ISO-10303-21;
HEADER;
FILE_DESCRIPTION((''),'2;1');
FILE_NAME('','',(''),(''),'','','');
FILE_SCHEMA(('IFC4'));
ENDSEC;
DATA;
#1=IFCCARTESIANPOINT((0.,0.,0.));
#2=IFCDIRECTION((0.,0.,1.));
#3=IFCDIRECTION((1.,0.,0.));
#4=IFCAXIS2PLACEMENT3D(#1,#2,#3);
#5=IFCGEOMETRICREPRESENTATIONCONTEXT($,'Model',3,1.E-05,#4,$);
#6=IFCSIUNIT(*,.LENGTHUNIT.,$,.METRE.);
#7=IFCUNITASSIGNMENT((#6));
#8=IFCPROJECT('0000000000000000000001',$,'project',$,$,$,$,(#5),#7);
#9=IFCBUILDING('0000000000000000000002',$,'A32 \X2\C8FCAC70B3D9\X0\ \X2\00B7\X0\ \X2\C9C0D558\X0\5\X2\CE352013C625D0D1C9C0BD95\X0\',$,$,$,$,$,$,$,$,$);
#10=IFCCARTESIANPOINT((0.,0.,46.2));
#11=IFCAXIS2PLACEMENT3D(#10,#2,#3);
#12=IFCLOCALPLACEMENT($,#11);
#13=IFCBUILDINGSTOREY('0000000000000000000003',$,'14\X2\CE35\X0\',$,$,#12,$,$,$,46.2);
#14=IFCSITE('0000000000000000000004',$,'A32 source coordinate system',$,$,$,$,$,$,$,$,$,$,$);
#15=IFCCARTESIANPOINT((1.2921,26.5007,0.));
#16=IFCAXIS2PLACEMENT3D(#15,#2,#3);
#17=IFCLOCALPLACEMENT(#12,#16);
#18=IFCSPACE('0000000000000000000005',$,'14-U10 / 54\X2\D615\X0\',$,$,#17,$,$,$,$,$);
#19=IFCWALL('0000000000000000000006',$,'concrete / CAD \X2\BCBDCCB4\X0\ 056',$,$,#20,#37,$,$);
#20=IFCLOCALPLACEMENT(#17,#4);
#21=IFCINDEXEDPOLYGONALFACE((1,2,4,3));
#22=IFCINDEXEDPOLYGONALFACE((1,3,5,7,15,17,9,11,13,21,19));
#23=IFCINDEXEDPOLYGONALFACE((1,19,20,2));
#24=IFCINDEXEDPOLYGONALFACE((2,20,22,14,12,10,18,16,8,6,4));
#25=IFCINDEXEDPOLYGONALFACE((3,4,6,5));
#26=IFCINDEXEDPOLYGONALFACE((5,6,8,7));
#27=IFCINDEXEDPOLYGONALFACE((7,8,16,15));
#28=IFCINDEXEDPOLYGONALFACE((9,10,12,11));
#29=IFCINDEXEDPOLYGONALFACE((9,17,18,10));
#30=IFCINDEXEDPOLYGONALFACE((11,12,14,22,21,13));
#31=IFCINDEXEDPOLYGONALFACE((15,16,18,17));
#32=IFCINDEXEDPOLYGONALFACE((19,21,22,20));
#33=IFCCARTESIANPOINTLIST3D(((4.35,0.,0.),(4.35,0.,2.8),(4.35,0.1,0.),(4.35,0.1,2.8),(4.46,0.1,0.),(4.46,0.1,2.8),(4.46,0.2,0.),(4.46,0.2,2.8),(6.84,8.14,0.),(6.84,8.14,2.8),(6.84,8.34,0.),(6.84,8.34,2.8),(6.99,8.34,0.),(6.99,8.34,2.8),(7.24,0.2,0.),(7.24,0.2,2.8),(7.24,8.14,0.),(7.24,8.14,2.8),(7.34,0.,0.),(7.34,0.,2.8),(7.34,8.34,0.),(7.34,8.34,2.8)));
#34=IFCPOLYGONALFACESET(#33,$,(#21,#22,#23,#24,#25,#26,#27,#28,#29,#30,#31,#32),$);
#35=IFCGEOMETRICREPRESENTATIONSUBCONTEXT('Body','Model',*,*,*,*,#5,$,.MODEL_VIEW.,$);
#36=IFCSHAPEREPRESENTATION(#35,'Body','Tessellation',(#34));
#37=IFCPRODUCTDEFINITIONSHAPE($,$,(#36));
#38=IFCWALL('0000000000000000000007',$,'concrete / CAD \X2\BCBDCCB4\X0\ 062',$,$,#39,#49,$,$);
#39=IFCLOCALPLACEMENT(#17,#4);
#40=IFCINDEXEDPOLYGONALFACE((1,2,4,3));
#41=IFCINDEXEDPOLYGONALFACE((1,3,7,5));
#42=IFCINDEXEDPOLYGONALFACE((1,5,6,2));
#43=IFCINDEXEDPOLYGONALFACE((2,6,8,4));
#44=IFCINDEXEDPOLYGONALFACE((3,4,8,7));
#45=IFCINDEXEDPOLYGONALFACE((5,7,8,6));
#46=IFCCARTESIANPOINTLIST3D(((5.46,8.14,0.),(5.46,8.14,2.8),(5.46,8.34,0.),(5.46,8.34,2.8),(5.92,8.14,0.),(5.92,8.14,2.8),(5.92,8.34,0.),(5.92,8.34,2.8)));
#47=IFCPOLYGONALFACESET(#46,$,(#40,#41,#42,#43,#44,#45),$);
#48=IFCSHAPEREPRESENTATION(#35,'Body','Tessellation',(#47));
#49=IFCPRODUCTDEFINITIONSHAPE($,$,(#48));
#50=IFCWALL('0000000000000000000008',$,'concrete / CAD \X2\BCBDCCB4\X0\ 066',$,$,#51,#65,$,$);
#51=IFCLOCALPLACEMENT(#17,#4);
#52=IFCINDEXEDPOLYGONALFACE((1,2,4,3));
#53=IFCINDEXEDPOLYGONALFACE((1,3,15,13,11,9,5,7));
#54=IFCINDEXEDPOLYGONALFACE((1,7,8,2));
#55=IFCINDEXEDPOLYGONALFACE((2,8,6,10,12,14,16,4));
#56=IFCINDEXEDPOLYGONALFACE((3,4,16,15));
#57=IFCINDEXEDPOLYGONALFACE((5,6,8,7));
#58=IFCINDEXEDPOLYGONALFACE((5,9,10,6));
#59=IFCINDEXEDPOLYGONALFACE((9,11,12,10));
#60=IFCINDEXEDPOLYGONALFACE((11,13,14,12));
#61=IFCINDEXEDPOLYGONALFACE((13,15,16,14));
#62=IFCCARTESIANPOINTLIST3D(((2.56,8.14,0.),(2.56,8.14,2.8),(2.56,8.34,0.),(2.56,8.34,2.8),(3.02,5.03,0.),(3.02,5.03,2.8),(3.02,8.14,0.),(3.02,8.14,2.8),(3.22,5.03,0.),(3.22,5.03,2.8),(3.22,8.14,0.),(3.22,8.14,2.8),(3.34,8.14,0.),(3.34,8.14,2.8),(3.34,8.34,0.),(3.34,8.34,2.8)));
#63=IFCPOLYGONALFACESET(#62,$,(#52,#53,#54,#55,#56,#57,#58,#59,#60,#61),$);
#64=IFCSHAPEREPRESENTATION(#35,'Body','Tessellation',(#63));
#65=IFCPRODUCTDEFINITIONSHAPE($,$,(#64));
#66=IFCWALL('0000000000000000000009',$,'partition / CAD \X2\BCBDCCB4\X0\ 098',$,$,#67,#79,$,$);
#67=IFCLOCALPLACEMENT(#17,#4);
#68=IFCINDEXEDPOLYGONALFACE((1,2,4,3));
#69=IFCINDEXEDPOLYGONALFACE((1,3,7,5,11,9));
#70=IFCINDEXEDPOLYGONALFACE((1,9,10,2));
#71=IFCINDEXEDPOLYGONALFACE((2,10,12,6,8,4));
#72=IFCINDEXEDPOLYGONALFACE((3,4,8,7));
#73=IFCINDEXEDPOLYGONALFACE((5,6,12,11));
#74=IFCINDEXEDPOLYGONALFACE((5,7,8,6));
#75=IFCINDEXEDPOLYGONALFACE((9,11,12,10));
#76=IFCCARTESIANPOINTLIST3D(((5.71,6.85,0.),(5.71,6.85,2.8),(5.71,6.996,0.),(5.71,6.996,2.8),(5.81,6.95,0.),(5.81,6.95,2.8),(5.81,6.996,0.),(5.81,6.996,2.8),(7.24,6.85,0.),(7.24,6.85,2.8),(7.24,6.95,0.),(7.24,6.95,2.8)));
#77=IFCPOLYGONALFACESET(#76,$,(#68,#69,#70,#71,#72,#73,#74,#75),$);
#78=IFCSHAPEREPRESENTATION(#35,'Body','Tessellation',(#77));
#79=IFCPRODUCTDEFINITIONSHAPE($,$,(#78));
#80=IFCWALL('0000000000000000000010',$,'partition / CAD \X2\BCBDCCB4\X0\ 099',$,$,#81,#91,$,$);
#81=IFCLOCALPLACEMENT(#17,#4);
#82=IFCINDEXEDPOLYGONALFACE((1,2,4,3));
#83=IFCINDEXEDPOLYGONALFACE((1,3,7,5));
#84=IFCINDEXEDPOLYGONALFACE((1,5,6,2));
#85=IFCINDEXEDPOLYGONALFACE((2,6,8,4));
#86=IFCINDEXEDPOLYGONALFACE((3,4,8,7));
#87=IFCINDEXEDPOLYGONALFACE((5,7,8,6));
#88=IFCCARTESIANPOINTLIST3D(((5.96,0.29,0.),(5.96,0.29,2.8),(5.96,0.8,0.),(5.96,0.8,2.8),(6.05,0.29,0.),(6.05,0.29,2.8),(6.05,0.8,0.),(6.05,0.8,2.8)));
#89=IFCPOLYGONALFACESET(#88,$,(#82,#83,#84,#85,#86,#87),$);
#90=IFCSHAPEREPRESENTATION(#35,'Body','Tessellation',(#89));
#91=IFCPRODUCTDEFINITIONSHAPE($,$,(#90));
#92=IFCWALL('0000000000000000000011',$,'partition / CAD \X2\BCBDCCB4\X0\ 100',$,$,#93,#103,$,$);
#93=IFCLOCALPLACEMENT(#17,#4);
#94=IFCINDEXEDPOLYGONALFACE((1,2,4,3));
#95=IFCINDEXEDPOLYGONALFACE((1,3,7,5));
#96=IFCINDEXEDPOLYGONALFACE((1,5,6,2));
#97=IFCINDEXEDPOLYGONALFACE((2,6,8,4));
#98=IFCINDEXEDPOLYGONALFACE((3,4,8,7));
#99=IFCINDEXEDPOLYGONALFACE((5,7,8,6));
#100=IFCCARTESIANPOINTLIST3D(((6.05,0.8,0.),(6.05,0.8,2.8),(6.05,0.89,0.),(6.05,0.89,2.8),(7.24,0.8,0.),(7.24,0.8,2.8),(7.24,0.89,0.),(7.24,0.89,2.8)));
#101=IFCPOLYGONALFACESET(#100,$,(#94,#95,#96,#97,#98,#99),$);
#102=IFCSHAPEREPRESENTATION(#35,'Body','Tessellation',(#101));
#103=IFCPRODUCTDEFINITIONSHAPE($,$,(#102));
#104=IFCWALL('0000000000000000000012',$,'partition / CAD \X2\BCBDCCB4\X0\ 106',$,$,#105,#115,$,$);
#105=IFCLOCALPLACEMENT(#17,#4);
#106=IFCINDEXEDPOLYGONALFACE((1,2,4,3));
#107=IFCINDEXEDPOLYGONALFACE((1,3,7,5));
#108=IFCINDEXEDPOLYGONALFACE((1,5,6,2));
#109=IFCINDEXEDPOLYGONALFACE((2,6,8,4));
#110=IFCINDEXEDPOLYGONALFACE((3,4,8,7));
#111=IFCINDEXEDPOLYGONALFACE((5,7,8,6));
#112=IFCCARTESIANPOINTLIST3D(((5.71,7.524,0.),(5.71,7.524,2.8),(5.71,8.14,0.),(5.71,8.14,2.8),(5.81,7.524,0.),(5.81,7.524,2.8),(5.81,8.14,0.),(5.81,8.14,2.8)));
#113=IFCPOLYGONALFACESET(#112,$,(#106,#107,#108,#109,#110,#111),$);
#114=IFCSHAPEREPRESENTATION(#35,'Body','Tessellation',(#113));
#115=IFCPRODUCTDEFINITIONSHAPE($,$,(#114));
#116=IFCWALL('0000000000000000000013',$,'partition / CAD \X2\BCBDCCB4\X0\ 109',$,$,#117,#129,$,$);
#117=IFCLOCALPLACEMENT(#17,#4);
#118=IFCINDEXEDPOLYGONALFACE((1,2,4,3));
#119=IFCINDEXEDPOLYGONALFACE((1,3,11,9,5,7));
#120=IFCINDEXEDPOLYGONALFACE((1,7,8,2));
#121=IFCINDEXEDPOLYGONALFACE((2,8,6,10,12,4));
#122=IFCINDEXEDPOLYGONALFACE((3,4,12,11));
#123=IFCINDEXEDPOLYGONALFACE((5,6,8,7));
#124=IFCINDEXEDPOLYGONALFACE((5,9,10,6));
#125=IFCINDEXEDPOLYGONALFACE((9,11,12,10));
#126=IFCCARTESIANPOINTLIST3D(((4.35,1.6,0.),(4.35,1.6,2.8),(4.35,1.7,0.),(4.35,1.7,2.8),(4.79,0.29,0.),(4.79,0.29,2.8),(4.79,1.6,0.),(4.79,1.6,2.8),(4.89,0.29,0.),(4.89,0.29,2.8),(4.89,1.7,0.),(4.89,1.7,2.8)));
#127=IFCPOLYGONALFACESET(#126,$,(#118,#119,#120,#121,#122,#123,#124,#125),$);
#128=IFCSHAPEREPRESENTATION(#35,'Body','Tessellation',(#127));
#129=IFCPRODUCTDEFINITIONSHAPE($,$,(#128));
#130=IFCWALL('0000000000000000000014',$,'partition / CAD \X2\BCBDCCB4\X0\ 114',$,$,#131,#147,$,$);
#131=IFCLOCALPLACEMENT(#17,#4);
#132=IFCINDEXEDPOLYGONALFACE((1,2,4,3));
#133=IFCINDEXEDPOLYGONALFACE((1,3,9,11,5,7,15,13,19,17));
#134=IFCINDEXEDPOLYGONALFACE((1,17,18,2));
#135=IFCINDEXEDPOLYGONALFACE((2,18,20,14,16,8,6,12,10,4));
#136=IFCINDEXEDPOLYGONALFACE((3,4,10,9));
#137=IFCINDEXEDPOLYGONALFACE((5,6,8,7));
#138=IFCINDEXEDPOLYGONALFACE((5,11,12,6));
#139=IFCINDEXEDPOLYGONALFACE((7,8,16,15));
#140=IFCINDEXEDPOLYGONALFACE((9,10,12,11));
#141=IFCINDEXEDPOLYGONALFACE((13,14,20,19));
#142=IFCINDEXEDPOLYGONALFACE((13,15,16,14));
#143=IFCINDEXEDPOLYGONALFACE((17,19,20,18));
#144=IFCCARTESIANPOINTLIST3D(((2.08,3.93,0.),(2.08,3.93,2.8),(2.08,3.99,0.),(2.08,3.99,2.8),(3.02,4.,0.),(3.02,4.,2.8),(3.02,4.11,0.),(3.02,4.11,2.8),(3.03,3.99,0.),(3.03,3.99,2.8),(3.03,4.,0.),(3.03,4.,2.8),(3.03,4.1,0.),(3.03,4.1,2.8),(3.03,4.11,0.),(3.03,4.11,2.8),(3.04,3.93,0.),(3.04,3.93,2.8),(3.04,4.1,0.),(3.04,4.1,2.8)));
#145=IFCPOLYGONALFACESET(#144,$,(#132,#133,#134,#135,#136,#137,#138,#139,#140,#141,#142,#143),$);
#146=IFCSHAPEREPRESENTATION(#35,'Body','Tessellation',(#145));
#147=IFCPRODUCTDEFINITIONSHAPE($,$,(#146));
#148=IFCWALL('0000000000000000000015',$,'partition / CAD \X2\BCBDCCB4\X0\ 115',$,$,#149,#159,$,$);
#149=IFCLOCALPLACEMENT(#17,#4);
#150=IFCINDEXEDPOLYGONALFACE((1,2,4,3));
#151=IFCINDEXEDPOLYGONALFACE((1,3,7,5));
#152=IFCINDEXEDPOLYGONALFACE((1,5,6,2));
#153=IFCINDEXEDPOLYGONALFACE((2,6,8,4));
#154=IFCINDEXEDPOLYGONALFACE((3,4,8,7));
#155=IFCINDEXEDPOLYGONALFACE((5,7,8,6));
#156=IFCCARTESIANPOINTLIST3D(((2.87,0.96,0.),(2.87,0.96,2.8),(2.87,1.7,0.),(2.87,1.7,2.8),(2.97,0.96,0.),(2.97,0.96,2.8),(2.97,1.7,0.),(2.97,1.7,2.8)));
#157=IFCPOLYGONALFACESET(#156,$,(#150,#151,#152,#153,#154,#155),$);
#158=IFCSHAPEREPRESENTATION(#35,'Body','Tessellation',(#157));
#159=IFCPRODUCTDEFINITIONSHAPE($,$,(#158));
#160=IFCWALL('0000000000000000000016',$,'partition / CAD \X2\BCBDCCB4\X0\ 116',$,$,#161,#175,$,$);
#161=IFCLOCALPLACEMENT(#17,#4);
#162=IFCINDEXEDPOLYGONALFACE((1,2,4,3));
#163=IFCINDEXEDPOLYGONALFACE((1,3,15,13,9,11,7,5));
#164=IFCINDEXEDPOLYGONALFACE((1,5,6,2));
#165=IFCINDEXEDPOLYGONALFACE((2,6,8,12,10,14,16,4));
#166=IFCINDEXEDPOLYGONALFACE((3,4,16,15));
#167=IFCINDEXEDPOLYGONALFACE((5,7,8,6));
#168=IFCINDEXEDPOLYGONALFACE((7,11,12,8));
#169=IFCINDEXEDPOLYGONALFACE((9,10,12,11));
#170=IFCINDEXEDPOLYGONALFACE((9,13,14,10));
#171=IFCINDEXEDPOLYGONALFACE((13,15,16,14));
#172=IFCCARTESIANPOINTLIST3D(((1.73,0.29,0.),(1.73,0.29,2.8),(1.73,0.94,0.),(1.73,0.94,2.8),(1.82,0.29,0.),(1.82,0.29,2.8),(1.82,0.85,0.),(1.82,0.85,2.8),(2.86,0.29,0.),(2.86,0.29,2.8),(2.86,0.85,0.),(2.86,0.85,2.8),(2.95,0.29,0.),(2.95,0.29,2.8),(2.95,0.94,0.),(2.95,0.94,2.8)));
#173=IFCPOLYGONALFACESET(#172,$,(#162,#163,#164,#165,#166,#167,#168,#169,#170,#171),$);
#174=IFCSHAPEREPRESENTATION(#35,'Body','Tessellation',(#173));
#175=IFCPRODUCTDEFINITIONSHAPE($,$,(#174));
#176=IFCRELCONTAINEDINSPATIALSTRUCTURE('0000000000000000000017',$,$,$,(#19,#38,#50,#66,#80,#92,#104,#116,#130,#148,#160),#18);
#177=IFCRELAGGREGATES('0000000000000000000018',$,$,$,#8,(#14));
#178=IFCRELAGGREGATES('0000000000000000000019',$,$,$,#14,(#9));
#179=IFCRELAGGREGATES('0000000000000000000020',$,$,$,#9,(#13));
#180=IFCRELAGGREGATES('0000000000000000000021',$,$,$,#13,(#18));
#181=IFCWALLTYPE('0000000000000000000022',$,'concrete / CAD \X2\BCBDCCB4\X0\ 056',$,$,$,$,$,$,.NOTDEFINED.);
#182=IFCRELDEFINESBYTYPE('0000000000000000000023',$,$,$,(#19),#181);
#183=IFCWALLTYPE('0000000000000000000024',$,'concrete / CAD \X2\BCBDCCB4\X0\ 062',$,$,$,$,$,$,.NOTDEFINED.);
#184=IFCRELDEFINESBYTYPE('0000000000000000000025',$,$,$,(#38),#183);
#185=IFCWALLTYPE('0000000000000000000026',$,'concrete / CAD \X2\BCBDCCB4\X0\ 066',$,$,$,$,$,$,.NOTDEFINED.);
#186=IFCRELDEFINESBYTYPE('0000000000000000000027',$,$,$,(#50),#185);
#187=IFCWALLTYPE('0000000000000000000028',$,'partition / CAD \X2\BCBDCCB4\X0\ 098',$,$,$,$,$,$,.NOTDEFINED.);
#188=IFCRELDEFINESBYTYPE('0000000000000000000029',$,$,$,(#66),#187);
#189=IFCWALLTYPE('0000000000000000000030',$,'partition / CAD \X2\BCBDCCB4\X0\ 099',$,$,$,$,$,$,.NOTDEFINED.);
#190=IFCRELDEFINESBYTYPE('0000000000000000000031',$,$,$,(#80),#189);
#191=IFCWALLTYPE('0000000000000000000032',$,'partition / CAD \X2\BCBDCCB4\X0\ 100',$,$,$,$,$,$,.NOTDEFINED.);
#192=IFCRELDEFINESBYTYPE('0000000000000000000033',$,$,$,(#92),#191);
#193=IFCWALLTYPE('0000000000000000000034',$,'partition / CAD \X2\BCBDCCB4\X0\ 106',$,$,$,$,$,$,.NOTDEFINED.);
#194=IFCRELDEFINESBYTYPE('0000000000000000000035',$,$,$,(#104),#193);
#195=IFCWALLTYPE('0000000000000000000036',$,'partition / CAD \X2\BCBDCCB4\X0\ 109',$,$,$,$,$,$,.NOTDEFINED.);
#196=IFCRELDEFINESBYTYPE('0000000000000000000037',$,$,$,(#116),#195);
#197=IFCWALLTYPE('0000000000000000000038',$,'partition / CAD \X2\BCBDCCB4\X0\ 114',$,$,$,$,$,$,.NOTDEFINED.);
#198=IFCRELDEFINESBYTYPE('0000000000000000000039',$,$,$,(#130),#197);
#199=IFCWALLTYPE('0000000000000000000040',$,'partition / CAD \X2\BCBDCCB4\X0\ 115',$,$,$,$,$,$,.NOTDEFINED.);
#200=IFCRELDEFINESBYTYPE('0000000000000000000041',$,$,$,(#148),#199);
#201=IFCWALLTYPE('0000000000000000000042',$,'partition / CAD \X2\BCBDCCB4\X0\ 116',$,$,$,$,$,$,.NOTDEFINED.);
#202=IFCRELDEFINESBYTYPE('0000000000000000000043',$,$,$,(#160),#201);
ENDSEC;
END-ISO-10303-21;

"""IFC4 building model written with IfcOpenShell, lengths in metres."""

from ifc_helpers import new_model, si_unit, frame, origin, origin_with_axes, place, context, subcontext, project, spatial, polyline, outline, extrude, source, transform, mapped, type_object, type_shapes, element, save


model = new_model("IFC4")

# Units and contexts
model_context = context("Model", 3, precision=1e-05, world=origin_with_axes())
body_context = subcontext(model_context, "Body", "Model", "MODEL_VIEW")
ifc_project = project(units=[si_unit("LENGTHUNIT", "METRE")], contexts=[model_context])

# Site, building, storey, space
site = spatial("IfcSite", under=ifc_project, Name="A32 source coordinate system")
building = spatial("IfcBuilding", under=site, Name="A32 주거동 · 지하5층–옥탑지붕")
storey_placement = place(None, frame((0.0, 0.0, 46.2), z_axis=(0.0, 0.0, 1.0), x_axis=(1.0, 0.0, 0.0)))
storey = spatial("IfcBuildingStorey", under=building, at=storey_placement, Name="14층", Elevation=46.2)
space_placement = place(storey_placement, frame((1.2921, 26.5007, 0.0), z_axis=(0.0, 0.0, 1.0), x_axis=(1.0, 0.0, 0.0)))
space = spatial("IfcSpace", under=storey, at=space_placement, Name="14-U10 / 54형")

# Walls
wall_type_1 = type_object("IfcWallType", Name="concrete / CAD 벽체 056", PredefinedType="NOTDEFINED")
shared_shape_1 = source(origin(), body_context, "Body", "SweptSolid", [
    extrude(outline(polyline([(7.24, 0.2), (7.24, 8.14), (6.84, 8.14), (6.84, 8.34), (6.99, 8.34), (6.99, 8.34), (7.34, 8.34), (7.34, 0.0), (4.35, 0.0), (4.35, 0.1), (4.46, 0.1), (4.46, 0.2), (7.24, 0.2)])), origin(), (0.0, 0.0, 1.0), 2.8),
])
type_shapes(wall_type_1, [shared_shape_1])
wall_1_placement = place(space_placement, origin_with_axes())
element("IfcWall", 1, at=wall_1_placement, inside=space, type_object=wall_type_1, Name="concrete / CAD 벽체 056", context=body_context, shape_type="MappedRepresentation", body=[
    mapped(shared_shape_1, transform((0.0, 0.0, 0.0), scale=1.0)),
])
wall_type_2 = type_object("IfcWallType", Name="concrete / CAD 벽체 062", PredefinedType="NOTDEFINED")
shared_shape_2 = source(origin(), body_context, "Body", "SweptSolid", [
    extrude(outline(polyline([(5.46, 8.14), (5.46, 8.34), (5.92, 8.34), (5.92, 8.14), (5.46, 8.14)])), origin(), (0.0, 0.0, 1.0), 2.8),
])
type_shapes(wall_type_2, [shared_shape_2])
wall_2_placement = place(space_placement, origin_with_axes())
element("IfcWall", 2, at=wall_2_placement, inside=space, type_object=wall_type_2, Name="concrete / CAD 벽체 062", context=body_context, shape_type="MappedRepresentation", body=[
    mapped(shared_shape_2, transform((0.0, 0.0, 0.0), scale=1.0)),
])
wall_type_3 = type_object("IfcWallType", Name="concrete / CAD 벽체 066", PredefinedType="NOTDEFINED")
shared_shape_3 = source(origin(), body_context, "Body", "SweptSolid", [
    extrude(outline(polyline([(3.22, 8.14), (3.22, 5.03), (3.02, 5.03), (3.02, 8.14), (2.56, 8.14), (2.56, 8.34), (3.34, 8.34), (3.34, 8.14), (3.22, 8.14)])), origin(), (0.0, 0.0, 1.0), 2.8),
])
type_shapes(wall_type_3, [shared_shape_3])
wall_3_placement = place(space_placement, origin_with_axes())
element("IfcWall", 3, at=wall_3_placement, inside=space, type_object=wall_type_3, Name="concrete / CAD 벽체 066", context=body_context, shape_type="MappedRepresentation", body=[
    mapped(shared_shape_3, transform((0.0, 0.0, 0.0), scale=1.0)),
])
wall_type_4 = type_object("IfcWallType", Name="partition / CAD 벽체 098", PredefinedType="NOTDEFINED")
shared_shape_4 = source(origin(), body_context, "Body", "SweptSolid", [
    extrude(outline(polyline([(5.71, 6.996), (5.81, 6.996), (5.81, 6.95), (7.24, 6.95), (7.24, 6.85), (5.71, 6.85), (5.71, 6.996)])), origin(), (0.0, 0.0, 1.0), 2.8),
])
type_shapes(wall_type_4, [shared_shape_4])
wall_4_placement = place(space_placement, origin_with_axes())
element("IfcWall", 4, at=wall_4_placement, inside=space, type_object=wall_type_4, Name="partition / CAD 벽체 098", context=body_context, shape_type="MappedRepresentation", body=[
    mapped(shared_shape_4, transform((0.0, 0.0, 0.0), scale=1.0)),
])
wall_type_5 = type_object("IfcWallType", Name="partition / CAD 벽체 099", PredefinedType="NOTDEFINED")
shared_shape_5 = source(origin(), body_context, "Body", "SweptSolid", [
    extrude(outline(polyline([(6.05, 0.8), (6.05, 0.29), (5.96, 0.29), (5.96, 0.8), (6.05, 0.8)])), origin(), (0.0, 0.0, 1.0), 2.8),
])
type_shapes(wall_type_5, [shared_shape_5])
wall_5_placement = place(space_placement, origin_with_axes())
element("IfcWall", 5, at=wall_5_placement, inside=space, type_object=wall_type_5, Name="partition / CAD 벽체 099", context=body_context, shape_type="MappedRepresentation", body=[
    mapped(shared_shape_5, transform((0.0, 0.0, 0.0), scale=1.0)),
])
wall_type_6 = type_object("IfcWallType", Name="partition / CAD 벽체 100", PredefinedType="NOTDEFINED")
shared_shape_6 = source(origin(), body_context, "Body", "SweptSolid", [
    extrude(outline(polyline([(7.24, 0.8), (6.05, 0.8), (6.05, 0.89), (7.24, 0.89), (7.24, 0.8)])), origin(), (0.0, 0.0, 1.0), 2.8),
])
type_shapes(wall_type_6, [shared_shape_6])
wall_6_placement = place(space_placement, origin_with_axes())
element("IfcWall", 6, at=wall_6_placement, inside=space, type_object=wall_type_6, Name="partition / CAD 벽체 100", context=body_context, shape_type="MappedRepresentation", body=[
    mapped(shared_shape_6, transform((0.0, 0.0, 0.0), scale=1.0)),
])
wall_type_7 = type_object("IfcWallType", Name="partition / CAD 벽체 106", PredefinedType="NOTDEFINED")
shared_shape_7 = source(origin(), body_context, "Body", "SweptSolid", [
    extrude(outline(polyline([(5.71, 8.14), (5.81, 8.14), (5.81, 7.524), (5.71, 7.524), (5.71, 8.14)])), origin(), (0.0, 0.0, 1.0), 2.8),
])
type_shapes(wall_type_7, [shared_shape_7])
wall_7_placement = place(space_placement, origin_with_axes())
element("IfcWall", 7, at=wall_7_placement, inside=space, type_object=wall_type_7, Name="partition / CAD 벽체 106", context=body_context, shape_type="MappedRepresentation", body=[
    mapped(shared_shape_7, transform((0.0, 0.0, 0.0), scale=1.0)),
])
wall_type_8 = type_object("IfcWallType", Name="partition / CAD 벽체 109", PredefinedType="NOTDEFINED")
shared_shape_8 = source(origin(), body_context, "Body", "SweptSolid", [
    extrude(outline(polyline([(4.79, 1.6), (4.35, 1.6), (4.35, 1.7), (4.89, 1.7), (4.89, 0.29), (4.79, 0.29), (4.79, 1.6)])), origin(), (0.0, 0.0, 1.0), 2.8),
])
type_shapes(wall_type_8, [shared_shape_8])
wall_8_placement = place(space_placement, origin_with_axes())
element("IfcWall", 8, at=wall_8_placement, inside=space, type_object=wall_type_8, Name="partition / CAD 벽체 109", context=body_context, shape_type="MappedRepresentation", body=[
    mapped(shared_shape_8, transform((0.0, 0.0, 0.0), scale=1.0)),
])
wall_type_9 = type_object("IfcWallType", Name="partition / CAD 벽체 114", PredefinedType="NOTDEFINED")
shared_shape_9 = source(origin(), body_context, "Body", "SweptSolid", [
    extrude(outline(polyline([(2.08, 3.99), (3.03, 3.99), (3.03, 4.0), (3.02, 4.0), (3.02, 4.11), (3.03, 4.11), (3.03, 4.1), (3.04, 4.1), (3.04, 3.93), (2.08, 3.93), (2.08, 3.99)])), origin(), (0.0, 0.0, 1.0), 2.8),
])
type_shapes(wall_type_9, [shared_shape_9])
wall_9_placement = place(space_placement, origin_with_axes())
element("IfcWall", 9, at=wall_9_placement, inside=space, type_object=wall_type_9, Name="partition / CAD 벽체 114", context=body_context, shape_type="MappedRepresentation", body=[
    mapped(shared_shape_9, transform((0.0, 0.0, 0.0), scale=1.0)),
])
wall_type_10 = type_object("IfcWallType", Name="partition / CAD 벽체 115", PredefinedType="NOTDEFINED")
shared_shape_10 = source(origin(), body_context, "Body", "SweptSolid", [
    extrude(outline(polyline([(2.87, 1.7), (2.97, 1.7), (2.97, 0.96), (2.87, 0.96), (2.87, 1.7)])), origin(), (0.0, 0.0, 1.0), 2.8),
])
type_shapes(wall_type_10, [shared_shape_10])
wall_10_placement = place(space_placement, origin_with_axes())
element("IfcWall", 10, at=wall_10_placement, inside=space, type_object=wall_type_10, Name="partition / CAD 벽체 115", context=body_context, shape_type="MappedRepresentation", body=[
    mapped(shared_shape_10, transform((0.0, 0.0, 0.0), scale=1.0)),
])
wall_type_11 = type_object("IfcWallType", Name="partition / CAD 벽체 116", PredefinedType="NOTDEFINED")
shared_shape_11 = source(origin(), body_context, "Body", "SweptSolid", [
    extrude(outline(polyline([(2.95, 0.29), (2.86, 0.29), (2.86, 0.85), (1.82, 0.85), (1.82, 0.29), (1.73, 0.29), (1.73, 0.94), (2.95, 0.94), (2.95, 0.29)])), origin(), (0.0, 0.0, 1.0), 2.8),
])
type_shapes(wall_type_11, [shared_shape_11])
wall_11_placement = place(space_placement, origin_with_axes())
element("IfcWall", 11, at=wall_11_placement, inside=space, type_object=wall_type_11, Name="partition / CAD 벽체 116", context=body_context, shape_type="MappedRepresentation", body=[
    mapped(shared_shape_11, transform((0.0, 0.0, 0.0), scale=1.0)),
])

save(model, "model.ifc")
